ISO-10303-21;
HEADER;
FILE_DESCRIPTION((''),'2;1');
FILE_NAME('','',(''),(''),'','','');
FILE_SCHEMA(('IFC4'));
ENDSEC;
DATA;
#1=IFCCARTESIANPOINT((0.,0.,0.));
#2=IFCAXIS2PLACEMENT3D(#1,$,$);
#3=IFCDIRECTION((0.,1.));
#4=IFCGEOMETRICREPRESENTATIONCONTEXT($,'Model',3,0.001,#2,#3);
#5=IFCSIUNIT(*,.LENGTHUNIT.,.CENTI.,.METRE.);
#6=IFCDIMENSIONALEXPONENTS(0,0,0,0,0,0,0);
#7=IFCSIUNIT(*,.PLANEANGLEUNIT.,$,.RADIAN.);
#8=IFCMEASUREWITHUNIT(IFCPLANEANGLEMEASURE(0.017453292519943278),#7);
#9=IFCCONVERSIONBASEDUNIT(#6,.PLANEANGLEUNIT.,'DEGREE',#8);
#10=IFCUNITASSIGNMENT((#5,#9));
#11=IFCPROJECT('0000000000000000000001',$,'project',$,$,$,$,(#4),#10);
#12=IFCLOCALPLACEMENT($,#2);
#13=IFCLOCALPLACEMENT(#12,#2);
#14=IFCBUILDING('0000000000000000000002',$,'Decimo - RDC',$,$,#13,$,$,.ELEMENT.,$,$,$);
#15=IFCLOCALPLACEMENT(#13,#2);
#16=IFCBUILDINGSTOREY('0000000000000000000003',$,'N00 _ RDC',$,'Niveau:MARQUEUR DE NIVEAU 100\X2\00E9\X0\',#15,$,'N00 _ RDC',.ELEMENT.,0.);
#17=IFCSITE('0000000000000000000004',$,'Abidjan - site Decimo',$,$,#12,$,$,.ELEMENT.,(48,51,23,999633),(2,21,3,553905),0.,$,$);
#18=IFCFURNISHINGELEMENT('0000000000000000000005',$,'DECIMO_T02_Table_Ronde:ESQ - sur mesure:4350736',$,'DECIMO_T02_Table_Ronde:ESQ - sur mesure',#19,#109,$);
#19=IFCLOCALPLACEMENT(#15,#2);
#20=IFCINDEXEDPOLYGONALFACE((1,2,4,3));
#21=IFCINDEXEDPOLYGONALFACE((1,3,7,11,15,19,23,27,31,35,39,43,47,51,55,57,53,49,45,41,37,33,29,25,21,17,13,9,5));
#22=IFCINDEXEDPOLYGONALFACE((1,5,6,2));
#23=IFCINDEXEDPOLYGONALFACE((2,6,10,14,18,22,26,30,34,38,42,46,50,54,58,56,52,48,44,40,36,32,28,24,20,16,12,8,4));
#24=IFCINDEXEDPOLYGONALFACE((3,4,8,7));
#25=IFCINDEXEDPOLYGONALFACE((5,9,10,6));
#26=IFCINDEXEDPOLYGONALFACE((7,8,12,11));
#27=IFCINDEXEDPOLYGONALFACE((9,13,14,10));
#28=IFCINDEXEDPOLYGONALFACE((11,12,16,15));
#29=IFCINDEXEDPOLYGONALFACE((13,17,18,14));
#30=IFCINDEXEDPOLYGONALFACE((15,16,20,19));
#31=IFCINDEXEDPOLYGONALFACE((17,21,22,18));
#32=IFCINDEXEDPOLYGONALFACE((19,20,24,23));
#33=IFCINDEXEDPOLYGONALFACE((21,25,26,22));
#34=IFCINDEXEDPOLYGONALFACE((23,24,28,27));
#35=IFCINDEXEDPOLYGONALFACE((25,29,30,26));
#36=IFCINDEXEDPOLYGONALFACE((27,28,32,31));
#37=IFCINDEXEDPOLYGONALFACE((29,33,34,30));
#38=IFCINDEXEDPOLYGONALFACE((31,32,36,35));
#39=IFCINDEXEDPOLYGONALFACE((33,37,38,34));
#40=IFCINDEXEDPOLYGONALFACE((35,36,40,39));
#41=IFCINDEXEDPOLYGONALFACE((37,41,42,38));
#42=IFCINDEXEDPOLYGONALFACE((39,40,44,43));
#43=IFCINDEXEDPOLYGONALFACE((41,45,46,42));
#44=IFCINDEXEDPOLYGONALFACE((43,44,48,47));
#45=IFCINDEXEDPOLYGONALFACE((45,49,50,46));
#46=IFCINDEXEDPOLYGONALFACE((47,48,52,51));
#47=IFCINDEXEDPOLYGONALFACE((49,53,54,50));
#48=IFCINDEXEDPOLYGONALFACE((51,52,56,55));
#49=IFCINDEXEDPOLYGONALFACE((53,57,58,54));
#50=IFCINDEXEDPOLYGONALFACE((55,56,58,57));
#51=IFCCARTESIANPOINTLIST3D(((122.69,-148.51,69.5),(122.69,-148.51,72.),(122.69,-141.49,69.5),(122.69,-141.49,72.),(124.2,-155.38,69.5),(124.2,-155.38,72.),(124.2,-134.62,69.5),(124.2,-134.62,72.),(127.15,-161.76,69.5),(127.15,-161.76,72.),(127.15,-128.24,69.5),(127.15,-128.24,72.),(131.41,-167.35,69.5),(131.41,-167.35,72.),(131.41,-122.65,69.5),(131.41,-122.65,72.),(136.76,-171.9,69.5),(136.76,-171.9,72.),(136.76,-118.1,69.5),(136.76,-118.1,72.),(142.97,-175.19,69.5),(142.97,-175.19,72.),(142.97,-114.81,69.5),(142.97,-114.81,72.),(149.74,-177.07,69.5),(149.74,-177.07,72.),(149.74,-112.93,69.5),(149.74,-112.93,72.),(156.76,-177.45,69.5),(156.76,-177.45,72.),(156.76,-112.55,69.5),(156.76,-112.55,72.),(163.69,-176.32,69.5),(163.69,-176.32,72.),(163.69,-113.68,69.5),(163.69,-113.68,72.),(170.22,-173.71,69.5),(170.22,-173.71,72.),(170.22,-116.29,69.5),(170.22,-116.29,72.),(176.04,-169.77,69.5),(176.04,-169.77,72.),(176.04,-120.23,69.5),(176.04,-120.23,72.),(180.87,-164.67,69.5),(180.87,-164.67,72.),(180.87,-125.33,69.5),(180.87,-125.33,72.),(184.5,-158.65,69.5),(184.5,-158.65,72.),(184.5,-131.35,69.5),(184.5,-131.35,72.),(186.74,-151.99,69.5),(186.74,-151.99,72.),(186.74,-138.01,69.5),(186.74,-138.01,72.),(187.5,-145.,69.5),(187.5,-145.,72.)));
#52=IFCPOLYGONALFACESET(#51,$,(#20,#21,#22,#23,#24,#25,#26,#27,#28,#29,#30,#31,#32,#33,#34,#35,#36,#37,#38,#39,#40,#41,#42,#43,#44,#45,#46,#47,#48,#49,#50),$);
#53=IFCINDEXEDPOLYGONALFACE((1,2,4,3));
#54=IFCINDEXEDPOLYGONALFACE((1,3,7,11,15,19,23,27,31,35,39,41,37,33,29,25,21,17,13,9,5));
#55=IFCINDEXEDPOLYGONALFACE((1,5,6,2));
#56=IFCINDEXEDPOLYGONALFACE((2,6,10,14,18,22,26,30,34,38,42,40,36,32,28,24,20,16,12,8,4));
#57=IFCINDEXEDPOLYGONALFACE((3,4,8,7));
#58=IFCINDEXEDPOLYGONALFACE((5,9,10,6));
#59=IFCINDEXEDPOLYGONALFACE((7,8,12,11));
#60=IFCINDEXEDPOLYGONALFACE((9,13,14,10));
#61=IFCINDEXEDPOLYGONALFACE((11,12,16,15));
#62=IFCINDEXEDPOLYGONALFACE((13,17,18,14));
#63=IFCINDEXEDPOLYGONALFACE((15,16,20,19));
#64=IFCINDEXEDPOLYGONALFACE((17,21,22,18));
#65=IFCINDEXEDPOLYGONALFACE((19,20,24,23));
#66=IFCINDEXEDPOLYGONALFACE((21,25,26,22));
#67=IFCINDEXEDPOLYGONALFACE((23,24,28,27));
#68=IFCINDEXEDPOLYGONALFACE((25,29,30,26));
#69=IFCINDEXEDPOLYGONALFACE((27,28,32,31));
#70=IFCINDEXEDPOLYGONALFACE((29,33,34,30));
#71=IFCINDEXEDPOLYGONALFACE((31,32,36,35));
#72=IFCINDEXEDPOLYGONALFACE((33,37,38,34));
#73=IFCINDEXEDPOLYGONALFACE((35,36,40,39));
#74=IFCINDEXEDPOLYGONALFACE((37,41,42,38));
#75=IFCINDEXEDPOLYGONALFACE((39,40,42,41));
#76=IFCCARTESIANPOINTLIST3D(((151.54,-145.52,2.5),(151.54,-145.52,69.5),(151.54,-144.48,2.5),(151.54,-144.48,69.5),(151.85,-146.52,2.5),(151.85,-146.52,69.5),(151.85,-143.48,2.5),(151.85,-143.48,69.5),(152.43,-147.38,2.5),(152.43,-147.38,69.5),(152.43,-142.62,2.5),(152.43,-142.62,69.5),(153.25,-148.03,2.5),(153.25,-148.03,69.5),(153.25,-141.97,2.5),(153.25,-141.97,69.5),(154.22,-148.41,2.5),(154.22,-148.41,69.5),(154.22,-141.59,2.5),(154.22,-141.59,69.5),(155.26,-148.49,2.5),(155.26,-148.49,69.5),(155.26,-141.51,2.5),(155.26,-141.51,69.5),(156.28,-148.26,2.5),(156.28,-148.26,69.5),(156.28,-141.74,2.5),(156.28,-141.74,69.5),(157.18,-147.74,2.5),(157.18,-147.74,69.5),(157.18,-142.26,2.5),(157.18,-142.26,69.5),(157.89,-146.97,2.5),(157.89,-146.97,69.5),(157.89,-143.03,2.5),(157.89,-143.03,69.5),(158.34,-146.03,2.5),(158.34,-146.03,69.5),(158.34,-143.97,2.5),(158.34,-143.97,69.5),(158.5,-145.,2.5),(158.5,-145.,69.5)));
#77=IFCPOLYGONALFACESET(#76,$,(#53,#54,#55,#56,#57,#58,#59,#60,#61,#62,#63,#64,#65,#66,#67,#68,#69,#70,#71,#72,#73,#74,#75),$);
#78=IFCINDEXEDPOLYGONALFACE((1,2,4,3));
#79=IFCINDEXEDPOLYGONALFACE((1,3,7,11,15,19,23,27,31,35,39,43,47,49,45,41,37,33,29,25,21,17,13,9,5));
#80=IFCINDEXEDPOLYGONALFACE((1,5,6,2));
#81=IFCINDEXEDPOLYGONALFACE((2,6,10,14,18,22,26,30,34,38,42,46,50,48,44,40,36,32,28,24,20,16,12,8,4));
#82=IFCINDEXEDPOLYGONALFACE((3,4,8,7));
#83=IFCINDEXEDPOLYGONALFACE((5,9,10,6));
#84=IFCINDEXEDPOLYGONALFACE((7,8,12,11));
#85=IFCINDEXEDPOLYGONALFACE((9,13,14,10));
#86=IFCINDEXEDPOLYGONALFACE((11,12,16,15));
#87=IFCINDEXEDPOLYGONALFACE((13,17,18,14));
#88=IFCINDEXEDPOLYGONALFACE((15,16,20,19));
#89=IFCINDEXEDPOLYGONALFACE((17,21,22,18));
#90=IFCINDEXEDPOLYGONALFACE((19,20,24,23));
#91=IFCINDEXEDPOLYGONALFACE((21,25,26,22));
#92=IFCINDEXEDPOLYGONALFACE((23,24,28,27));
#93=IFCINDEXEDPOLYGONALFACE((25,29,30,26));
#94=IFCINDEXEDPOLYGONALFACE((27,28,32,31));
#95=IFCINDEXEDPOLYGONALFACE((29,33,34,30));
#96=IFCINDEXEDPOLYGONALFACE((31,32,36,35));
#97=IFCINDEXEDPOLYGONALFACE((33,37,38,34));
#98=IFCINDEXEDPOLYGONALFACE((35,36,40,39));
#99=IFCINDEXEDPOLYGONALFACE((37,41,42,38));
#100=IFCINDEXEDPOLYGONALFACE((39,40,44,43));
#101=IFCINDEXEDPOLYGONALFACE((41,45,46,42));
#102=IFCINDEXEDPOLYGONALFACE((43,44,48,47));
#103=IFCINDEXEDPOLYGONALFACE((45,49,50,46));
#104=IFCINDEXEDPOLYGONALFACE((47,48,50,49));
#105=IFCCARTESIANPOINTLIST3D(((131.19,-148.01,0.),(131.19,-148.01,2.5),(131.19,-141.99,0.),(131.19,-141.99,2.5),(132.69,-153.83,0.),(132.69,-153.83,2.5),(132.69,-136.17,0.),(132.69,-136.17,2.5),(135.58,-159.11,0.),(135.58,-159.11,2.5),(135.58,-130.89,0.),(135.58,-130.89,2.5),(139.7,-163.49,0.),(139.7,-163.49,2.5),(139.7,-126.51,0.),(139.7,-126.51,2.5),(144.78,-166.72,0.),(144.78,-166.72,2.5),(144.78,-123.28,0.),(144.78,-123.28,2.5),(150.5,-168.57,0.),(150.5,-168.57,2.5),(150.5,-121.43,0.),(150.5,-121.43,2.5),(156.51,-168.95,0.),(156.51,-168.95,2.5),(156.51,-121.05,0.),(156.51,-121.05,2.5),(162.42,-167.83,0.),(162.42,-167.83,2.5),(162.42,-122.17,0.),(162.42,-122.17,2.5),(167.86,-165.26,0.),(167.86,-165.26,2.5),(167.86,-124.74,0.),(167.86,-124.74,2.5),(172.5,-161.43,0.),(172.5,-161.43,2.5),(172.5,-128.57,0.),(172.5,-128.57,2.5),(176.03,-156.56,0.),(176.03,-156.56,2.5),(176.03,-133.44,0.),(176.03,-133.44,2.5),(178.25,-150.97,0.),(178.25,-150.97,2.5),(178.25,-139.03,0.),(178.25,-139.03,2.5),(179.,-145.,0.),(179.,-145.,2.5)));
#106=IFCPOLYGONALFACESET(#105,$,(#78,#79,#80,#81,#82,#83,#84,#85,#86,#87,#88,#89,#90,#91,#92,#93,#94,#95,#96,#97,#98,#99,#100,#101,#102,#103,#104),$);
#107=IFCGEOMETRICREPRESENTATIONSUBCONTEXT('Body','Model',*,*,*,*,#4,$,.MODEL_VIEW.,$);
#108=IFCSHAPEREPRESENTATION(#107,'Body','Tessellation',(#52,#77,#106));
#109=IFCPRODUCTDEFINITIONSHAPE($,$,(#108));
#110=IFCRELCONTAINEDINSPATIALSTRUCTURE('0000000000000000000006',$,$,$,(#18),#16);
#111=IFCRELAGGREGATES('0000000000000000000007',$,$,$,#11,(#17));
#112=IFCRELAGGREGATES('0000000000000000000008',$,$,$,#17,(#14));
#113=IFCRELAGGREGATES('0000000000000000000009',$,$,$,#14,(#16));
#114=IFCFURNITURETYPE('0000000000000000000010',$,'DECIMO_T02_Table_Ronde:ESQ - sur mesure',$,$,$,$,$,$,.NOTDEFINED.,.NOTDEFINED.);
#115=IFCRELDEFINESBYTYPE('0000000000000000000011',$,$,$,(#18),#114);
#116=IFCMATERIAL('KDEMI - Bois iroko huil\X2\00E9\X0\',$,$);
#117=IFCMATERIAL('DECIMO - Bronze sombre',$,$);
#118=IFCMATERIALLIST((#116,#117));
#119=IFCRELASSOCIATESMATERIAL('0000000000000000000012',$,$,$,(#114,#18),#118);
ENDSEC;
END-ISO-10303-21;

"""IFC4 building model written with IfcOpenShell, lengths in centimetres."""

from ifc_helpers import new_model, entity, si_unit, converted_unit, direction, frame, frame_2d, origin, place, context, subcontext, project, spatial, circle, extrude, source, transform, mapped, material, material_list, type_object, type_shapes, element, save


model = new_model("IFC4")

# Units and contexts
model_context = context("Model", 3, precision=0.001, world=origin(), true_north=direction((0.0, 1.0)))
body_context = subcontext(model_context, "Body", "Model", "MODEL_VIEW")
ifc_project = project(units=[si_unit("LENGTHUNIT", "METRE", prefix="CENTI"), converted_unit("PLANEANGLEUNIT", "DEGREE", entity("IfcPlaneAngleMeasure", 0.017453292519943278), si_unit("PLANEANGLEUNIT", "RADIAN"), dimensions=[0, 0, 0, 0, 0, 0, 0])], contexts=[model_context])

# Site, building, storey
site_placement = place(None, origin())
site = spatial("IfcSite", under=ifc_project, at=site_placement, Name="Abidjan - site Decimo", CompositionType="ELEMENT", RefLatitude=(48, 51, 23, 999633), RefLongitude=(2, 21, 3, 553905), RefElevation=0.0)
building_placement = place(site_placement, origin())
building = spatial("IfcBuilding", under=site, at=building_placement, Name="Decimo - RDC", CompositionType="ELEMENT")
storey_placement = place(building_placement, origin())
storey = spatial("IfcBuildingStorey", under=building, at=storey_placement, Name="N00 _ RDC", ObjectType="Niveau:MARQUEUR DE NIVEAU 100é", LongName="N00 _ RDC", CompositionType="ELEMENT", Elevation=0.0)

# Furnishing element
ifc_material_1 = material(Name="KDEMI - Bois iroko huilé")
ifc_material_2 = material(Name="DECIMO - Bronze sombre")
ifc_material_list_1 = material_list([ifc_material_1, ifc_material_2])
furniture_type_1 = type_object("IfcFurnitureType", Name="DECIMO_T02_Table_Ronde:ESQ - sur mesure", AssemblyPlace="NOTDEFINED", material=ifc_material_list_1)
shared_shape_1 = source(origin(), body_context, "Body", "SweptSolid", [
    extrude(circle(Radius=32.5, at=frame_2d((0.0, 0.0), x_axis=(1.0, 0.0))), frame((0.0, 0.0, 69.5)), (0.0, 0.0, 1.0), 2.5),
    extrude(circle(Radius=3.5, at=frame_2d((0.0, 0.0), x_axis=(1.0, 0.0))), frame((0.0, 0.0, 2.5)), (0.0, 0.0, 1.0), 67.0),
    extrude(circle(Radius=24.0, at=frame_2d((0.0, 0.0), x_axis=(1.0, 0.0))), origin(), (0.0, 0.0, 1.0), 2.5),
])
type_shapes(furniture_type_1, [shared_shape_1])
for number, where, name in (
    (1, (155.0, -145.0, 0.0), "DECIMO_T02_Table_Ronde:ESQ - sur mesure:4350736"),
):
    element("IfcFurnishingElement", number, at=place(storey_placement, frame(where)), inside=storey, type_object=furniture_type_1, material=ifc_material_list_1, Name=name, ObjectType="DECIMO_T02_Table_Ronde:ESQ - sur mesure", context=body_context, shape_type="MappedRepresentation", body=[
        mapped(shared_shape_1, transform((0.0, 0.0, 0.0), scale=1.0)),
    ])

save(model, "model.ifc")
